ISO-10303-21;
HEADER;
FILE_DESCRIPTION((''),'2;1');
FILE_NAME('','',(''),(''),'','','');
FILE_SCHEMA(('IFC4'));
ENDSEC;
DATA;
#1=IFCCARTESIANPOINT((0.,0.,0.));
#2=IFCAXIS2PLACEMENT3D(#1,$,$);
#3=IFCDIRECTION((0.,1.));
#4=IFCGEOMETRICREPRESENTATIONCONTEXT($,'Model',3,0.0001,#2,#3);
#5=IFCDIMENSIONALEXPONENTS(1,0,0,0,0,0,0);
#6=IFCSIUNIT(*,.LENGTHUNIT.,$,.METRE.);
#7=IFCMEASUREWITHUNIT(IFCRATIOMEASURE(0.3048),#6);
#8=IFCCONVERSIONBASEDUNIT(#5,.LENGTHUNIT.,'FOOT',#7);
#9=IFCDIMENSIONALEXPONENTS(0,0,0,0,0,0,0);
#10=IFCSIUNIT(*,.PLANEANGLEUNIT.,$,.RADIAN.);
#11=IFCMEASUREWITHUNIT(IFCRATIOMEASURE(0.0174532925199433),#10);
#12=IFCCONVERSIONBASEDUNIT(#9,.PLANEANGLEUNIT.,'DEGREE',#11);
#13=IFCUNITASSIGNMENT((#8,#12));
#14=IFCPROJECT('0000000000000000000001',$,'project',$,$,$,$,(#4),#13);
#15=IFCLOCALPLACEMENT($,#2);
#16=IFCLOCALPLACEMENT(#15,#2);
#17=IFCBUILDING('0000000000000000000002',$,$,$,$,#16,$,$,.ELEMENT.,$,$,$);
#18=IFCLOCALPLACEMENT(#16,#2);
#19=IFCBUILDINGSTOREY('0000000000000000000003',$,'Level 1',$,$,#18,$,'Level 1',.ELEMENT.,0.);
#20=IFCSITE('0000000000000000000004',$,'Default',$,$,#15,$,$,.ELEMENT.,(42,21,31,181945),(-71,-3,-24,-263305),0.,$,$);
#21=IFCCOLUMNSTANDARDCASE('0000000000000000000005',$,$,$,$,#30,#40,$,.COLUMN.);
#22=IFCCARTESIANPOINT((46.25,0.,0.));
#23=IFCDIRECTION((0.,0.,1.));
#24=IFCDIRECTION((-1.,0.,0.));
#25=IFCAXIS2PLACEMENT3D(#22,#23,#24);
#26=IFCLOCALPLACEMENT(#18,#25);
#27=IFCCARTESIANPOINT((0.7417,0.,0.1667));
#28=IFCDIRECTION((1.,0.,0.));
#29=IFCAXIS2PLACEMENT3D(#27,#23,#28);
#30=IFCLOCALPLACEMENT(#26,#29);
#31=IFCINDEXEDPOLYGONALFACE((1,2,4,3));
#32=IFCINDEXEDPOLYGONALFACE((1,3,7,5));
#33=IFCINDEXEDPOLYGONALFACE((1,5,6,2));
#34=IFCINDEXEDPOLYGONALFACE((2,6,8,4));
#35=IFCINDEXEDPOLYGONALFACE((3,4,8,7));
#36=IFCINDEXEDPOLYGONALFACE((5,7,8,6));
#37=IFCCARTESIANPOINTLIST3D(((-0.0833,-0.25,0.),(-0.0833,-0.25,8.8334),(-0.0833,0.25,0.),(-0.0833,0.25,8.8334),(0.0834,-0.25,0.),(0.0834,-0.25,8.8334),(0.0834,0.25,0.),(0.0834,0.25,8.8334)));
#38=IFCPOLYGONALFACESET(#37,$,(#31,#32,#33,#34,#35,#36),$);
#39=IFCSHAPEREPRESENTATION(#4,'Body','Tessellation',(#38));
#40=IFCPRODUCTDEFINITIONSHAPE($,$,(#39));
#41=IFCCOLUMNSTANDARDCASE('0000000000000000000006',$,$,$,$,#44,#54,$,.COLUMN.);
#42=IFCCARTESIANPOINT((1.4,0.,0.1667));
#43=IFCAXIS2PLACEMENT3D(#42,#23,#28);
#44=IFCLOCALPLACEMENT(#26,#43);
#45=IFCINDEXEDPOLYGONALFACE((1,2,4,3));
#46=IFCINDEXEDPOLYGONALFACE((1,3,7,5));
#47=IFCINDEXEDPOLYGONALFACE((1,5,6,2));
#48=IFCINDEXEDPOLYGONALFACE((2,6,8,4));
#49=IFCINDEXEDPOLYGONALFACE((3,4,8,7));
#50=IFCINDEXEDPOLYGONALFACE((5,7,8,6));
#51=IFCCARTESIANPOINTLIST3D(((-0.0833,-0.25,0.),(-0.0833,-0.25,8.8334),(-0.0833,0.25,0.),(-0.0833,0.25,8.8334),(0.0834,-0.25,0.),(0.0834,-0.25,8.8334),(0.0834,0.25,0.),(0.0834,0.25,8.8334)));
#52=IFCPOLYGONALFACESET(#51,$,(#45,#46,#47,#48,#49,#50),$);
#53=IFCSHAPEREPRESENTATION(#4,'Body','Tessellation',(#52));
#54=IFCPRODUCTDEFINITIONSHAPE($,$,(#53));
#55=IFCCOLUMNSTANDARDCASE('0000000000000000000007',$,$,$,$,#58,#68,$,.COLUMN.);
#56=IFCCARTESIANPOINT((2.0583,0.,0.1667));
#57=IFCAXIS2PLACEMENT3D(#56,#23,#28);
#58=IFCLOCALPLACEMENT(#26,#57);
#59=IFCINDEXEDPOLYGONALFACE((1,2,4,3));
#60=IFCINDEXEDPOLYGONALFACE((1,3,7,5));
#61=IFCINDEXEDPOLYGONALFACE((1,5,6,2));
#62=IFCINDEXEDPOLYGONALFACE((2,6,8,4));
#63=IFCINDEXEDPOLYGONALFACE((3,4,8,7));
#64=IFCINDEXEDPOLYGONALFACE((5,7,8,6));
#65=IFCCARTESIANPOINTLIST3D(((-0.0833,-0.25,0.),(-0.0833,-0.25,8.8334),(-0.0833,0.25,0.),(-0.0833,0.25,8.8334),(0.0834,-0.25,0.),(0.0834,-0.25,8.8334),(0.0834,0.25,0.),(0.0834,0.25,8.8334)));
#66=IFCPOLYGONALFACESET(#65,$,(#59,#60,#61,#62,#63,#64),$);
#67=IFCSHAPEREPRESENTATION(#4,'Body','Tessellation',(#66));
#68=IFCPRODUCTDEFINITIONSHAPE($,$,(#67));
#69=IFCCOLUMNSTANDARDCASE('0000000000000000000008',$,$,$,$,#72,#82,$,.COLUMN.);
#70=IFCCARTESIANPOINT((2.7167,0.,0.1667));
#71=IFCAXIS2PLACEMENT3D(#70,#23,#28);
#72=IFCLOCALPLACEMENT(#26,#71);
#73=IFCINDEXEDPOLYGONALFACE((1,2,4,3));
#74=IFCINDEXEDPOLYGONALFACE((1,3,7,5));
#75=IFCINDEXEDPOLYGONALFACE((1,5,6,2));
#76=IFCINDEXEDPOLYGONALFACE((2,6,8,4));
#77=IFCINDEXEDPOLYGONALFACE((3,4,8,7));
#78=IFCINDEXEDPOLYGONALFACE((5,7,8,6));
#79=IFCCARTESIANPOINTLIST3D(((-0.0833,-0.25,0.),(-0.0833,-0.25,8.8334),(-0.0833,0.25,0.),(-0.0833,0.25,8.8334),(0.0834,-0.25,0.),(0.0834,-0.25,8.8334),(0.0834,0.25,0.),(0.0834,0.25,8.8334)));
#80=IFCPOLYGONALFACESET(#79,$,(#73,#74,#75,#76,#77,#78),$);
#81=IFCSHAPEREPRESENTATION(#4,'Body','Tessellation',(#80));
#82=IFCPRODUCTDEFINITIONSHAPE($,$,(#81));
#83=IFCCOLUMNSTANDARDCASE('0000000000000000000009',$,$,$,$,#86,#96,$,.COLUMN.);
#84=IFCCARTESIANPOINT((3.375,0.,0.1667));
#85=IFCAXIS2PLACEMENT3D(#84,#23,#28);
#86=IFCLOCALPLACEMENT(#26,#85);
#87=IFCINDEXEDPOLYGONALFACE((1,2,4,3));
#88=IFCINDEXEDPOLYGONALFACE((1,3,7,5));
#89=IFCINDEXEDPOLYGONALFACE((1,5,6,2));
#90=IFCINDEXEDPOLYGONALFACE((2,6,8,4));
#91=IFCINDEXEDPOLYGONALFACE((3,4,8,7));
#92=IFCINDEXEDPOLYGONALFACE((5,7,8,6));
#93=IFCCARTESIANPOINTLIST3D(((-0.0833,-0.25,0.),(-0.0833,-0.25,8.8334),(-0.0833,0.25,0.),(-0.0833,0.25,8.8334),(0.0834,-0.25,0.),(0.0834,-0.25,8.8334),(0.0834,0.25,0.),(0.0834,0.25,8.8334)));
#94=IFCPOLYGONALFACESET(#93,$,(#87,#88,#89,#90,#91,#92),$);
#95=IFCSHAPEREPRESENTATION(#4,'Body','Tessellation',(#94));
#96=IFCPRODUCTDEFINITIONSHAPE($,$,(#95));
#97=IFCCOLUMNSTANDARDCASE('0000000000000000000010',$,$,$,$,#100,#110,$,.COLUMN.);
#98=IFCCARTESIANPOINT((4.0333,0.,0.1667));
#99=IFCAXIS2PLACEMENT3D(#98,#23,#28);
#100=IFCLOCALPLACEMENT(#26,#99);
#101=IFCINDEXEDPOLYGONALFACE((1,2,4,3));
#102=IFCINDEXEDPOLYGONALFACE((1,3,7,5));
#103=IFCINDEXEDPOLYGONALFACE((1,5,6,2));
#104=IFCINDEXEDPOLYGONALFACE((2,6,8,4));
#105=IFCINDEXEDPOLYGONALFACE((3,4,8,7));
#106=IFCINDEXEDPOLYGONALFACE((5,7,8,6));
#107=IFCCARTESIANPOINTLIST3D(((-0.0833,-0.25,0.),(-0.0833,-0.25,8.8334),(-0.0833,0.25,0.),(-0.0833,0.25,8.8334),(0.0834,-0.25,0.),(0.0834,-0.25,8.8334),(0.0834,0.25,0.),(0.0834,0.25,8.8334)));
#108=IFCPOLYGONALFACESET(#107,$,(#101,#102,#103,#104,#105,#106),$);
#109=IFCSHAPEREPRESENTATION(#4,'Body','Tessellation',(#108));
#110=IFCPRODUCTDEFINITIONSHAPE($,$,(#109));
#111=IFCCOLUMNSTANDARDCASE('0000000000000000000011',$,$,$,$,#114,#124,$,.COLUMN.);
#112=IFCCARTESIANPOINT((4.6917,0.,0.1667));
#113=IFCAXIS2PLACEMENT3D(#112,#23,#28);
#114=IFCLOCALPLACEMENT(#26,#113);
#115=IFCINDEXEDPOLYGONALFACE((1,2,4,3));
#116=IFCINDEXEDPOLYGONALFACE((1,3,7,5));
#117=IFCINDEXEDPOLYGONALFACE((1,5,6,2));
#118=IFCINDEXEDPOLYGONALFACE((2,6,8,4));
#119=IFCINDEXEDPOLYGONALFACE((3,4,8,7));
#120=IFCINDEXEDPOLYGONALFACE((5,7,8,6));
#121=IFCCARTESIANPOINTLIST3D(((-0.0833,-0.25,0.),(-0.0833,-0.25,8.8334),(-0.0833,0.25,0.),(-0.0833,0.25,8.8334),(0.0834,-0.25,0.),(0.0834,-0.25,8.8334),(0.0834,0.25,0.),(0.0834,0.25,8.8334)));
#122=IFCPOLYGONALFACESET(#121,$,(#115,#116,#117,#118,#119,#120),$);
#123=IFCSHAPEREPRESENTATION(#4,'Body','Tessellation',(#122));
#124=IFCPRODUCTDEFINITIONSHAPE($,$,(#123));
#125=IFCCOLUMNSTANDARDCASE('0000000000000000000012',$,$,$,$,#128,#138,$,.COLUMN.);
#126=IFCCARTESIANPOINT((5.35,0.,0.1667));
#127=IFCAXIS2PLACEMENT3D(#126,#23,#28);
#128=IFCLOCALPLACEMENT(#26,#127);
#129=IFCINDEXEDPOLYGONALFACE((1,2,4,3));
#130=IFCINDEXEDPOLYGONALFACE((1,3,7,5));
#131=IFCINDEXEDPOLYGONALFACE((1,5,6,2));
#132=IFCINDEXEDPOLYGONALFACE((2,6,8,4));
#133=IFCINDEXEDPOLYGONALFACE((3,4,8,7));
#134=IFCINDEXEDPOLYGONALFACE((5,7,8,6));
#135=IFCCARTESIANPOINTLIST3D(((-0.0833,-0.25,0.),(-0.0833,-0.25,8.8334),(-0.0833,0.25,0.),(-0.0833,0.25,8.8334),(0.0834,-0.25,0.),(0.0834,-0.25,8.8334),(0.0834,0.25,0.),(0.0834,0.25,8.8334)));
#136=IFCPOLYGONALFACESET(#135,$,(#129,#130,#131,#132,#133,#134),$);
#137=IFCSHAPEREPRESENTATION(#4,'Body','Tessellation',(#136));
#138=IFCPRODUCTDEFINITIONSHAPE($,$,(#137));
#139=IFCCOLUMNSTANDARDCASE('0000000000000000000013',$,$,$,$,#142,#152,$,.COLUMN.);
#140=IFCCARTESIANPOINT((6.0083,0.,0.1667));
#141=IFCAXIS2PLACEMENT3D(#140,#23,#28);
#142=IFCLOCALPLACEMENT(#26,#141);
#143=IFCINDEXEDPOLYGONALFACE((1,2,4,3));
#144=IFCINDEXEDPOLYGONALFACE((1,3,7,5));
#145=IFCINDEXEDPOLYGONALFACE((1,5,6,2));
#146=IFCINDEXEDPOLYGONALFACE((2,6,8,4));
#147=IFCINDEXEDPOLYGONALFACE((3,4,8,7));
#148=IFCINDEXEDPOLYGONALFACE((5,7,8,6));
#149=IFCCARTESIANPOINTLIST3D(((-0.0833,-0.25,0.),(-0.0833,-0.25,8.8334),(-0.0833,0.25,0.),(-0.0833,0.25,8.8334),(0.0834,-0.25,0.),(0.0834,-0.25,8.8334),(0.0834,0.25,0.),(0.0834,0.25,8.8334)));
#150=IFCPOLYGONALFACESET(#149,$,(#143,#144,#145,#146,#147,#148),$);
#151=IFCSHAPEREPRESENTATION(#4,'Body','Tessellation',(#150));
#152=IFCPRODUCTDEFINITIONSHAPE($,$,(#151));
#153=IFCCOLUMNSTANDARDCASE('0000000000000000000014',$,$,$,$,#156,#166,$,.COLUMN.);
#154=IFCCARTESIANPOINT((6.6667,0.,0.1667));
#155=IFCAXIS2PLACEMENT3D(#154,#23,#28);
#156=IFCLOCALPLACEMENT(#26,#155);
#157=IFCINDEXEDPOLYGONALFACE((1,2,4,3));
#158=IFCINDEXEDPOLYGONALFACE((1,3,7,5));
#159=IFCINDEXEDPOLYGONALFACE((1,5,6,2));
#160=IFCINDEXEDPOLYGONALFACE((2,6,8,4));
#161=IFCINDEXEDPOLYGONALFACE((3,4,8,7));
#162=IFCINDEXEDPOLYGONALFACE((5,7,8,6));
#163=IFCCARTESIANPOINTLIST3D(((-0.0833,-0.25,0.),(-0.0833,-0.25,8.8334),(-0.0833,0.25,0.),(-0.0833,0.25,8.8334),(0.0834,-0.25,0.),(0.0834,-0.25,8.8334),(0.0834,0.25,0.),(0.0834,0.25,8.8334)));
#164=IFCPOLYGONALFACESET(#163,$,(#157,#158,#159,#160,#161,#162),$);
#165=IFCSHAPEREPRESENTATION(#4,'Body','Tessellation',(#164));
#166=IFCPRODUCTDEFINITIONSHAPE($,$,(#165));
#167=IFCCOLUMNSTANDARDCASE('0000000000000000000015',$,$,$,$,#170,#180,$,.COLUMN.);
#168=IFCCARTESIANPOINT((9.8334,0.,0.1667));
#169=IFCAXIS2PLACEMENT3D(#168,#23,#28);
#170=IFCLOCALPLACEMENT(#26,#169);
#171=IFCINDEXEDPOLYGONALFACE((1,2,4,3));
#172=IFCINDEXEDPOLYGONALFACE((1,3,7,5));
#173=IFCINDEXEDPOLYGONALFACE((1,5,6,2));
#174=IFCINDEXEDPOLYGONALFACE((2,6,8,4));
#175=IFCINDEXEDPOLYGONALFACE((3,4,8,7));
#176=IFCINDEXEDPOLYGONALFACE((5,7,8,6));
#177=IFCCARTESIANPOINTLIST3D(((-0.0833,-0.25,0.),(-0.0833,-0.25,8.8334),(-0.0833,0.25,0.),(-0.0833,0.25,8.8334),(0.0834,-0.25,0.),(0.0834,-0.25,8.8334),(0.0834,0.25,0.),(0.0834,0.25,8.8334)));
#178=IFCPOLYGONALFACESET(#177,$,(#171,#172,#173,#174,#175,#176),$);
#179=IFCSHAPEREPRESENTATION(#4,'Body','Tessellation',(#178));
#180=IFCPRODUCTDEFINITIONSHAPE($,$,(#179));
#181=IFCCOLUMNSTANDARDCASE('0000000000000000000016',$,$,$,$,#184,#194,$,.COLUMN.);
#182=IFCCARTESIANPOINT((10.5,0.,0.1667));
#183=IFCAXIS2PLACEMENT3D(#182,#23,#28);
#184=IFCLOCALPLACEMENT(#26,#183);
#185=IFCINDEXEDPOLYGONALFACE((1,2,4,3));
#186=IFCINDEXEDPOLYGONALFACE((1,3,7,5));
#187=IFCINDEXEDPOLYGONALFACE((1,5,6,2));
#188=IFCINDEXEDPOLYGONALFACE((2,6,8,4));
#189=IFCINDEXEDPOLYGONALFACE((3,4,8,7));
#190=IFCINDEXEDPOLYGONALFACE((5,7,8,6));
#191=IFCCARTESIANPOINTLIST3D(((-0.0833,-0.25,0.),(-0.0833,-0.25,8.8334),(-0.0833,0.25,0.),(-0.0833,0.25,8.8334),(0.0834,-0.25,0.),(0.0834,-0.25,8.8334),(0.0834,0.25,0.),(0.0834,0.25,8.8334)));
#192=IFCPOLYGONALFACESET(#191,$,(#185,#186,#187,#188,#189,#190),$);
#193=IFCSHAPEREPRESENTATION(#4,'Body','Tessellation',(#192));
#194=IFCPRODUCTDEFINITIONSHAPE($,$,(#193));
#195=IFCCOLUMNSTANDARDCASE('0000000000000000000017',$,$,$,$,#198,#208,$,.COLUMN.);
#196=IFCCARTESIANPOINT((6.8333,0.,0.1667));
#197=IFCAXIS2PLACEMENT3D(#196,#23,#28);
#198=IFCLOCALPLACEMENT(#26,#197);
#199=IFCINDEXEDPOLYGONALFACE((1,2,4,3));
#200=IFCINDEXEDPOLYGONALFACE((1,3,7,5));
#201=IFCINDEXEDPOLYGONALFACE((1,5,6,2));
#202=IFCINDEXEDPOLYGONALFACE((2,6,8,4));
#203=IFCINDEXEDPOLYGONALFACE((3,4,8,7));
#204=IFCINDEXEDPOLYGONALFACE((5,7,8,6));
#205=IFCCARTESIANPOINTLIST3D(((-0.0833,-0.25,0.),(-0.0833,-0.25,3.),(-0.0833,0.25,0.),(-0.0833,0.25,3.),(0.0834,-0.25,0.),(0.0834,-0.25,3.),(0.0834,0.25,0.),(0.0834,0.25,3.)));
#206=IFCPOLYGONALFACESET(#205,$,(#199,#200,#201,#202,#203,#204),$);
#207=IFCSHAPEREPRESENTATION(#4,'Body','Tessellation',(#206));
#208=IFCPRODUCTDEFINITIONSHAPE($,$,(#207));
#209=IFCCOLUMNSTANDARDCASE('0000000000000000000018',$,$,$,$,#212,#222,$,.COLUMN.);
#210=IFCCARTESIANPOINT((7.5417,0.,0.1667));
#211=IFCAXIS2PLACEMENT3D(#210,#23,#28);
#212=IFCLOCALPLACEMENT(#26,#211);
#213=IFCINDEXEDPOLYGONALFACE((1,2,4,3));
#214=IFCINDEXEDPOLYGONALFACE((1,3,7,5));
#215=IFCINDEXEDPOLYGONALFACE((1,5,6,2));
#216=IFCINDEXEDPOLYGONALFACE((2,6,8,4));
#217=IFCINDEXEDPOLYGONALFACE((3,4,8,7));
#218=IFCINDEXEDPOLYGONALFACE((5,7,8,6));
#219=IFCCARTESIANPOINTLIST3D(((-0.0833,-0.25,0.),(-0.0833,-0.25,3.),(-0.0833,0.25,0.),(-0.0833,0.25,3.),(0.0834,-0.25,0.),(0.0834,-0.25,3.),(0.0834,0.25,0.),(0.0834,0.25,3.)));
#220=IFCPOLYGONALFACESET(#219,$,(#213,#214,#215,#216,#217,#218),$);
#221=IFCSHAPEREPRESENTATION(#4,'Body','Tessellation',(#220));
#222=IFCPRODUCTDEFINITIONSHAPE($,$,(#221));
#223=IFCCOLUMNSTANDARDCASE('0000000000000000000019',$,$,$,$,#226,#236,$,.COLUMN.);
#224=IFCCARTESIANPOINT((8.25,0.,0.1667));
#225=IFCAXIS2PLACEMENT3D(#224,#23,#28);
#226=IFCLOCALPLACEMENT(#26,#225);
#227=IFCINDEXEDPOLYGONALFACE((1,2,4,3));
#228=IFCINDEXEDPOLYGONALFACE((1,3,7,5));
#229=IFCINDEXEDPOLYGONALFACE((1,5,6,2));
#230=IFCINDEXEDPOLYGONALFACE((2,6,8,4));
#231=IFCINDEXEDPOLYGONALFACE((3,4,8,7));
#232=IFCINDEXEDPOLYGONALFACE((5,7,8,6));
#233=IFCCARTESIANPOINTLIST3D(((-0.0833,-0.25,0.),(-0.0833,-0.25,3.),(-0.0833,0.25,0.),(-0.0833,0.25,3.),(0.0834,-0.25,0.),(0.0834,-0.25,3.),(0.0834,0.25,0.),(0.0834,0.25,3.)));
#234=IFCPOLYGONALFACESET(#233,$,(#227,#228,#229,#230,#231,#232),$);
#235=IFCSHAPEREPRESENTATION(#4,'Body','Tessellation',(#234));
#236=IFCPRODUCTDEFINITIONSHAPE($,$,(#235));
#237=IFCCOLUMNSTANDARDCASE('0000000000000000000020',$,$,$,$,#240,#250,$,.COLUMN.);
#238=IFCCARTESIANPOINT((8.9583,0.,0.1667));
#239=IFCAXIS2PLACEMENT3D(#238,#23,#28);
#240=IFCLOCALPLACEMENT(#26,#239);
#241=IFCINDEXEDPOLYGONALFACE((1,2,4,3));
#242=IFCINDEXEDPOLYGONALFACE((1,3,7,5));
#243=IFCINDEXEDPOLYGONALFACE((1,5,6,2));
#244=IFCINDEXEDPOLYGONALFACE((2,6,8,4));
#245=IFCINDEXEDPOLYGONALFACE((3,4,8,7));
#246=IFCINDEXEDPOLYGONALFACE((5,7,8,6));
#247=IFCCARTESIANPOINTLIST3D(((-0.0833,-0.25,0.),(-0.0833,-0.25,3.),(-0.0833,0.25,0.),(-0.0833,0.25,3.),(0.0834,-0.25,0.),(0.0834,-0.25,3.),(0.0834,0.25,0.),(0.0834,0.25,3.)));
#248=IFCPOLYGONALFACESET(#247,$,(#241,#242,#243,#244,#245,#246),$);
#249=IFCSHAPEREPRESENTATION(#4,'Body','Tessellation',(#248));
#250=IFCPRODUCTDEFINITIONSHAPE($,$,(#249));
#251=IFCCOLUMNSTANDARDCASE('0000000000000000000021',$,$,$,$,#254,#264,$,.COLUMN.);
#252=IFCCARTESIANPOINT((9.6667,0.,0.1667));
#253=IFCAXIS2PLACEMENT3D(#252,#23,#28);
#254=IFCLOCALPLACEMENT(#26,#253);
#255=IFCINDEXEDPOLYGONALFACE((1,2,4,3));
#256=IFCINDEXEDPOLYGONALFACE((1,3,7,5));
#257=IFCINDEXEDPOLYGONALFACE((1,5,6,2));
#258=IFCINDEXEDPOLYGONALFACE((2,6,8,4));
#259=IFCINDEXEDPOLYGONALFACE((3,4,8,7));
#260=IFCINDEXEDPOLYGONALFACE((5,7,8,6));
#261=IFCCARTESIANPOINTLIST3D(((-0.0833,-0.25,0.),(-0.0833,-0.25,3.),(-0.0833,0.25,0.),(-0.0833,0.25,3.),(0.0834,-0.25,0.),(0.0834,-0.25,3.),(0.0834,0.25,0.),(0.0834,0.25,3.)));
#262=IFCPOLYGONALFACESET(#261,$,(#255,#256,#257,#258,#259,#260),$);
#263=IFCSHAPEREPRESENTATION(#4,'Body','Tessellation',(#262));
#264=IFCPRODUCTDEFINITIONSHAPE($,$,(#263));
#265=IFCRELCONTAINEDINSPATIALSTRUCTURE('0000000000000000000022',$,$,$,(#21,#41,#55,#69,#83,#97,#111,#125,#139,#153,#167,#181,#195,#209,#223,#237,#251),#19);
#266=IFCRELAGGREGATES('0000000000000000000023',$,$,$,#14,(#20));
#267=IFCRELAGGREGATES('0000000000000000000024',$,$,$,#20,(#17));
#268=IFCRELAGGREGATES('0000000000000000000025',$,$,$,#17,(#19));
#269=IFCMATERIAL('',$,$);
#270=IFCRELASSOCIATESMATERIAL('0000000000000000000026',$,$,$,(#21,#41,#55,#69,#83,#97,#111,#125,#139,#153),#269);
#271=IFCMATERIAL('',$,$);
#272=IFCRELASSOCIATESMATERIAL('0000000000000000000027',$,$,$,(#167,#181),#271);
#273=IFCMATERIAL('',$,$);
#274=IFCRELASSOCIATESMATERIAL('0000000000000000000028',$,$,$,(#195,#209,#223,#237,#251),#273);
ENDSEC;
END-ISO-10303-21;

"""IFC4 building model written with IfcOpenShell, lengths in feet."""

from ifc_helpers import new_model, entity, si_unit, converted_unit, direction, frame, origin, place, context, project, spatial, rectangle, extrude, material, element, save


model = new_model("IFC4")

# Units and contexts
model_context = context("Model", 3, precision=0.0001, world=origin(), true_north=direction((0.0, 1.0)))
ifc_project = project(units=[converted_unit("LENGTHUNIT", "FOOT", entity("IfcRatioMeasure", 0.3048), si_unit("LENGTHUNIT", "METRE"), dimensions=[1, 0, 0, 0, 0, 0, 0]), converted_unit("PLANEANGLEUNIT", "DEGREE", entity("IfcRatioMeasure", 0.0174532925199433), si_unit("PLANEANGLEUNIT", "RADIAN"), dimensions=[0, 0, 0, 0, 0, 0, 0])], contexts=[model_context])

# Site, building, storey
site_placement = place(None, origin())
site = spatial("IfcSite", under=ifc_project, at=site_placement, Name="Default", CompositionType="ELEMENT", RefLatitude=(42, 21, 31, 181945), RefLongitude=(-71, -3, -24, -263305), RefElevation=0.0)
building_placement = place(site_placement, origin())
building = spatial("IfcBuilding", under=site, at=building_placement, CompositionType="ELEMENT")
storey_placement = place(building_placement, origin())
storey = spatial("IfcBuildingStorey", under=building, at=storey_placement, Name="Level 1", LongName="Level 1", CompositionType="ELEMENT", Elevation=0.0)

# Columns
ifc_material_1 = material(Name="")
placement = place(storey_placement, frame((46.25, 0.0, 0.0), z_axis=(0.0, 0.0, 1.0), x_axis=(-1.0, 0.0, 0.0)))
for number, where, z_axis, x_axis in (
    (1, (0.7417, 0.0, 0.1667), (0.0, 0.0, 1.0), (1.0, 0.0, 0.0)),
    (2, (1.4, 0.0, 0.1667), (0.0, 0.0, 1.0), (1.0, 0.0, 0.0)),
    (3, (2.0583, 0.0, 0.1667), (0.0, 0.0, 1.0), (1.0, 0.0, 0.0)),
    (4, (2.7167, 0.0, 0.1667), (0.0, 0.0, 1.0), (1.0, 0.0, 0.0)),
    (5, (3.375, 0.0, 0.1667), (0.0, 0.0, 1.0), (1.0, 0.0, 0.0)),
    (6, (4.0333, 0.0, 0.1667), (0.0, 0.0, 1.0), (1.0, 0.0, 0.0)),
    (7, (4.6917, 0.0, 0.1667), (0.0, 0.0, 1.0), (1.0, 0.0, 0.0)),
    (8, (5.35, 0.0, 0.1667), (0.0, 0.0, 1.0), (1.0, 0.0, 0.0)),
    (9, (6.0083, 0.0, 0.1667), (0.0, 0.0, 1.0), (1.0, 0.0, 0.0)),
    (10, (6.6667, 0.0, 0.1667), (0.0, 0.0, 1.0), (1.0, 0.0, 0.0)),
):
    element("IfcColumnStandardCase", number, at=place(placement, frame(where, z_axis=z_axis, x_axis=x_axis)), inside=storey, material=ifc_material_1, PredefinedType="COLUMN", context=model_context, shape_type="SweptSolid", body=[
        extrude(rectangle(XDim=0.1667, YDim=0.5), origin(), (0.0, 0.0, 1.0), 8.8334),
    ])
ifc_material_2 = material(Name="")
for number, where, z_axis, x_axis in (
    (11, (9.8334, 0.0, 0.1667), (0.0, 0.0, 1.0), (1.0, 0.0, 0.0)),
    (12, (10.5, 0.0, 0.1667), (0.0, 0.0, 1.0), (1.0, 0.0, 0.0)),
):
    element("IfcColumnStandardCase", number, at=place(placement, frame(where, z_axis=z_axis, x_axis=x_axis)), inside=storey, material=ifc_material_2, PredefinedType="COLUMN", context=model_context, shape_type="SweptSolid", body=[
        extrude(rectangle(XDim=0.1667, YDim=0.5), origin(), (0.0, 0.0, 1.0), 8.8334),
    ])
ifc_material_3 = material(Name="")
for number, where, z_axis, x_axis in (
    (13, (6.8333, 0.0, 0.1667), (0.0, 0.0, 1.0), (1.0, 0.0, 0.0)),
    (14, (7.5417, 0.0, 0.1667), (0.0, 0.0, 1.0), (1.0, 0.0, 0.0)),
    (15, (8.25, 0.0, 0.1667), (0.0, 0.0, 1.0), (1.0, 0.0, 0.0)),
    (16, (8.9583, 0.0, 0.1667), (0.0, 0.0, 1.0), (1.0, 0.0, 0.0)),
    (17, (9.6667, 0.0, 0.1667), (0.0, 0.0, 1.0), (1.0, 0.0, 0.0)),
):
    element("IfcColumnStandardCase", number, at=place(placement, frame(where, z_axis=z_axis, x_axis=x_axis)), inside=storey, material=ifc_material_3, PredefinedType="COLUMN", context=model_context, shape_type="SweptSolid", body=[
        extrude(rectangle(XDim=0.1667, YDim=0.5), origin(), (0.0, 0.0, 1.0), 3.0),
    ])

save(model, "model.ifc")
